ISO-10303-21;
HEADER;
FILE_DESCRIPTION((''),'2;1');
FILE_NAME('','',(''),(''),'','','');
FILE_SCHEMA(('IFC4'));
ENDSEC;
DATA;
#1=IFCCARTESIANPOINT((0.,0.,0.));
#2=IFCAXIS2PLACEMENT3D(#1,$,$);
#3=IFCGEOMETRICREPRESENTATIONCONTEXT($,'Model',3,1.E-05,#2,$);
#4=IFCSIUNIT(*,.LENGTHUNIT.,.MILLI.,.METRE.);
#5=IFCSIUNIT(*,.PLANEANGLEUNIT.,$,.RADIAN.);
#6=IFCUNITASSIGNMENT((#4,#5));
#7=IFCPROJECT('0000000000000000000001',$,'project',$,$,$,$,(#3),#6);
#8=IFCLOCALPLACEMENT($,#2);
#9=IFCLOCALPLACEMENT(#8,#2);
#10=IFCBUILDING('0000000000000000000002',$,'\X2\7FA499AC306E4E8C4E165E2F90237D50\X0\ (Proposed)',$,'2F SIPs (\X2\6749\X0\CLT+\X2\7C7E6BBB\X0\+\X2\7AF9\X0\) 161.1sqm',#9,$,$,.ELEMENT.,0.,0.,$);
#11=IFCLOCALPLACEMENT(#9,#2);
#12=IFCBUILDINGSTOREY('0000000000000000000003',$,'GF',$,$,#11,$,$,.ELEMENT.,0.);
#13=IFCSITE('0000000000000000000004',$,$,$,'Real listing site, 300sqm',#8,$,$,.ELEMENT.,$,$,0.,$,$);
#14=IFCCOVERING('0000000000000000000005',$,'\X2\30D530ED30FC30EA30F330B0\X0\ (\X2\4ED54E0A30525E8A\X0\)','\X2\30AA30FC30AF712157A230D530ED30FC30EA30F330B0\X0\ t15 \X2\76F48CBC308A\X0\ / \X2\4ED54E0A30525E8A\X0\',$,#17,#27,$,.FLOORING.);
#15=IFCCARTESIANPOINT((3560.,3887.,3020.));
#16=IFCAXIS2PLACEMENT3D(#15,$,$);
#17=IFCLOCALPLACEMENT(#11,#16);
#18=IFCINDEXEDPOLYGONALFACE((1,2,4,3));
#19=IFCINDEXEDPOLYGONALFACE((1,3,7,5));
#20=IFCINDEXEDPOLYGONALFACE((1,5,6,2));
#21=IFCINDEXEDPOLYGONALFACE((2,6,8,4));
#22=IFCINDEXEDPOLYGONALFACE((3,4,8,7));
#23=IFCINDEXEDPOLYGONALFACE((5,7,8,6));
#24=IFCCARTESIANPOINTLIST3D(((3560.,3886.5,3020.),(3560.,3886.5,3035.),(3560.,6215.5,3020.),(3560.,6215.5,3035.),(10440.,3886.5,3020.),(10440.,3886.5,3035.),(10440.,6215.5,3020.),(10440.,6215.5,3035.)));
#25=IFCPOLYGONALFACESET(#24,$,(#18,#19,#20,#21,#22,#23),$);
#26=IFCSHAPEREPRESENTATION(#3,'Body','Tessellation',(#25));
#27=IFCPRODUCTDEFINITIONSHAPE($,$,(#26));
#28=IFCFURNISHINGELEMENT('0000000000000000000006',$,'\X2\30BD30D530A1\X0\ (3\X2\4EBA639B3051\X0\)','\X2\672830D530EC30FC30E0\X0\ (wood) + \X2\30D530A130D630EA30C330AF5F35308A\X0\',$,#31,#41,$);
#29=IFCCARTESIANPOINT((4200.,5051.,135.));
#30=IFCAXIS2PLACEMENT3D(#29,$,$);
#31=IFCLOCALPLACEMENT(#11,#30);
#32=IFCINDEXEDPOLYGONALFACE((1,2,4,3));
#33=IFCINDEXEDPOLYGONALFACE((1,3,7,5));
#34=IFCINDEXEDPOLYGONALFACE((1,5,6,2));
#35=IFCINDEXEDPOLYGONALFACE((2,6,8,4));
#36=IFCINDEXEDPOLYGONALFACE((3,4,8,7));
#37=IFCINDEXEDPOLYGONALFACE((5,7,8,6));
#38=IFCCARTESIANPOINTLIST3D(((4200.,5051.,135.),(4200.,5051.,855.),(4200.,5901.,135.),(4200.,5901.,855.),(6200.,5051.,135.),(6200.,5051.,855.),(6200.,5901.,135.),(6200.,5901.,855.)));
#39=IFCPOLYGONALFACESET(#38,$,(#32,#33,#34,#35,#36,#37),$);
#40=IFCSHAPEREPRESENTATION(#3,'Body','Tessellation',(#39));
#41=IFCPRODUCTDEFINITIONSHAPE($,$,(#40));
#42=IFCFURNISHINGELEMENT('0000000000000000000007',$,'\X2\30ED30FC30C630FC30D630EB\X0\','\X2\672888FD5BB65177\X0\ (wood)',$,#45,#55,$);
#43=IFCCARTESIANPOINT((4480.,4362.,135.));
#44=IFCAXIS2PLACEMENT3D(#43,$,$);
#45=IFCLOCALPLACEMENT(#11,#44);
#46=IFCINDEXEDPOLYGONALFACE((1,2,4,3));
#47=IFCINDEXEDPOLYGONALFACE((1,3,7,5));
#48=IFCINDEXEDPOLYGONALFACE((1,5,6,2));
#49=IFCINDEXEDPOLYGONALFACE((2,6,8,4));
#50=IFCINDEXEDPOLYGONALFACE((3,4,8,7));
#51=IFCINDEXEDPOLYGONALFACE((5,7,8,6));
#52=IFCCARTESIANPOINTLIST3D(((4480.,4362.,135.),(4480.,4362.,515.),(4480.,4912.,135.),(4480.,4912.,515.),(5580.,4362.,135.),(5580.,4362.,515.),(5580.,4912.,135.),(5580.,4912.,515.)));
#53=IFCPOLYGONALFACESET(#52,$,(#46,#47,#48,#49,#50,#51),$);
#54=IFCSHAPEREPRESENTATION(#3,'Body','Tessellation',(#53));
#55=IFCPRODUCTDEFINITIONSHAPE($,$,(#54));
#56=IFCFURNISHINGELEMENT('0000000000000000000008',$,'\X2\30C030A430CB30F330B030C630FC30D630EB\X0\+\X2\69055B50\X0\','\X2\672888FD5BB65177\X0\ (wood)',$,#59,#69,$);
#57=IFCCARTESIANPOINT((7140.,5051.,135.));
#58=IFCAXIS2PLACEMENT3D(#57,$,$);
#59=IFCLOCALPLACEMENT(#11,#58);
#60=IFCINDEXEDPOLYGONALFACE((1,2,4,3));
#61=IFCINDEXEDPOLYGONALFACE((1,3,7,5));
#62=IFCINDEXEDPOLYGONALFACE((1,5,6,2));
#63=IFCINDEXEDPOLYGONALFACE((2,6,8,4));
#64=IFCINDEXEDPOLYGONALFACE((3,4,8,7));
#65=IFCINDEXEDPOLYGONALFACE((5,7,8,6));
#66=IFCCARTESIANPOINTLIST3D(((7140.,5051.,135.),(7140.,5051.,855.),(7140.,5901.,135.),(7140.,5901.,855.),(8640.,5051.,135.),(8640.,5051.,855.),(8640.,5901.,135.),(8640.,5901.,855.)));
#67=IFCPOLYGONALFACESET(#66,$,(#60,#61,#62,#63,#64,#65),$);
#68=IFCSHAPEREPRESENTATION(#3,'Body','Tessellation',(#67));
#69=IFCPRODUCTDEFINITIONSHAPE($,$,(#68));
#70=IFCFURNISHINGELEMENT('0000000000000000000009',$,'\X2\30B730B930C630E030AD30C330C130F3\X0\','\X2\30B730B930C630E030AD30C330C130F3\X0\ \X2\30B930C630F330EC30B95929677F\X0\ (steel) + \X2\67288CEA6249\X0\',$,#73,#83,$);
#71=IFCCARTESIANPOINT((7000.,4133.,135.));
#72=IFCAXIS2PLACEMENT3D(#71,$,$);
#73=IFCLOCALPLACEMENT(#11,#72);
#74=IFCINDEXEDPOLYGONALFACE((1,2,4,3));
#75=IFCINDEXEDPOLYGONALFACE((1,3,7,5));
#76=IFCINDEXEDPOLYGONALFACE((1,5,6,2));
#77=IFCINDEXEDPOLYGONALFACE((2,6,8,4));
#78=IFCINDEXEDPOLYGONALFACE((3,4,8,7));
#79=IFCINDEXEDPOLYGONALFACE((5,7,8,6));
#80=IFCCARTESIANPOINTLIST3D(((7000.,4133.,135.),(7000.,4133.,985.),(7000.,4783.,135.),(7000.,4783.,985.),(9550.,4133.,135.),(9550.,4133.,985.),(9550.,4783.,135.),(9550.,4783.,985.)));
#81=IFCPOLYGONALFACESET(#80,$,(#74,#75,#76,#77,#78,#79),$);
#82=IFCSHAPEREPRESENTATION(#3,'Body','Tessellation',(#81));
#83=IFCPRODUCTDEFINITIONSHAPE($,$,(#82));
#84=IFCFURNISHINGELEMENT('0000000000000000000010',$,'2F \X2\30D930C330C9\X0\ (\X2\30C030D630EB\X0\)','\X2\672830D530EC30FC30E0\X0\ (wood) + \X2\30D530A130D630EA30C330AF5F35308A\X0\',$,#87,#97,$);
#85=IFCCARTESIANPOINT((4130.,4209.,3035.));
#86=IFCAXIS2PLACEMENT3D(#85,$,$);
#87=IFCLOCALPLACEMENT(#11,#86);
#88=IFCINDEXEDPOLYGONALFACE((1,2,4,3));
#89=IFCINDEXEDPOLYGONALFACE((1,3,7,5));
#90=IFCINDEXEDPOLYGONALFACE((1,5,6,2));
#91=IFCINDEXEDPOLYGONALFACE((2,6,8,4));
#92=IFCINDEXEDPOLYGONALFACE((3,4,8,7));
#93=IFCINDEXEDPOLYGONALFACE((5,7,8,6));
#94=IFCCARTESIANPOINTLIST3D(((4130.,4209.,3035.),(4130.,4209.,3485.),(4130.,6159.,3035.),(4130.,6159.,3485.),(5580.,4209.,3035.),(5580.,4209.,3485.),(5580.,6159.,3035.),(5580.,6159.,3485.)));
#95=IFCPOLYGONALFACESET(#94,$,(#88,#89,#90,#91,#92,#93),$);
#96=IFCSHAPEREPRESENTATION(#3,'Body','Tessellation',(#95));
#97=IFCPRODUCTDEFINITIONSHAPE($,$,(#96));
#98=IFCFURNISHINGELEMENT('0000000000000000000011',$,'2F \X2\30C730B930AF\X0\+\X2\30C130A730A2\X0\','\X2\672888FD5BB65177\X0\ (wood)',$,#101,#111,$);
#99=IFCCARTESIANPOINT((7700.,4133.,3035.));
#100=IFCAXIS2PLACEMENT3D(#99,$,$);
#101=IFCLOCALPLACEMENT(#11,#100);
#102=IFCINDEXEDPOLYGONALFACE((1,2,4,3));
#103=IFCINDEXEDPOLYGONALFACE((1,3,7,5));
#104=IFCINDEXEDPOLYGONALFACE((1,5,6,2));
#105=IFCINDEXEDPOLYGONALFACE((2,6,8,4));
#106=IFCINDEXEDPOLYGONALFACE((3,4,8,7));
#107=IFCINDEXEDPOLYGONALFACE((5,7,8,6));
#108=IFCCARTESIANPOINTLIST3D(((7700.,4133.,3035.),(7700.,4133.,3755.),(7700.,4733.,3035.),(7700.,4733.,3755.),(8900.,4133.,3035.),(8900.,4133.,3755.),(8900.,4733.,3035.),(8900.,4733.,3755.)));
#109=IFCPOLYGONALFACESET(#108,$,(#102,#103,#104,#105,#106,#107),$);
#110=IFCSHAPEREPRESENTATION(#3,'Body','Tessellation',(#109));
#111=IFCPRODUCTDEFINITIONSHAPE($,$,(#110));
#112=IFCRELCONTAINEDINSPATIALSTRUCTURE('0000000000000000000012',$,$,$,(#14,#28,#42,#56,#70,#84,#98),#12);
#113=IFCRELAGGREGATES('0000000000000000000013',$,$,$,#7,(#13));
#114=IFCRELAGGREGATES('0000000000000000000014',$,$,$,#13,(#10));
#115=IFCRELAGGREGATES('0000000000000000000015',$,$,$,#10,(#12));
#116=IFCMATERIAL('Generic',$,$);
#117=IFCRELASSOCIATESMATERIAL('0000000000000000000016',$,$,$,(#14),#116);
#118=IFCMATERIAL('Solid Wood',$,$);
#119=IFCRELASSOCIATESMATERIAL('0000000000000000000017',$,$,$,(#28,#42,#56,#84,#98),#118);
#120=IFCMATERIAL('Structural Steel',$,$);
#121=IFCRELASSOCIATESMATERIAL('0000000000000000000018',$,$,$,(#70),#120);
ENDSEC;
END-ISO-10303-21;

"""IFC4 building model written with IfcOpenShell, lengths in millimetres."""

from ifc_helpers import new_model, si_unit, frame, frame_2d, origin, place, context, project, spatial, rectangle, extrude, material, element, save


model = new_model("IFC4")

# Units and contexts
model_context = context("Model", 3, precision=1e-05, world=origin())
ifc_project = project(units=[si_unit("LENGTHUNIT", "METRE", prefix="MILLI"), si_unit("PLANEANGLEUNIT", "RADIAN")], contexts=[model_context])

# Site, building, storey
site_placement = place(None, origin())
site = spatial("IfcSite", under=ifc_project, at=site_placement, ObjectType="Real listing site, 300sqm", CompositionType="ELEMENT", RefElevation=0.0)
building_placement = place(site_placement, origin())
building = spatial("IfcBuilding", under=site, at=building_placement, Name="群馬の二世帯連結 (Proposed)", ObjectType="2F SIPs (杉CLT+籾殻+竹) 161.1sqm", CompositionType="ELEMENT", ElevationOfRefHeight=0.0, ElevationOfTerrain=0.0)
storey_placement = place(building_placement, origin())
storey = spatial("IfcBuildingStorey", under=building, at=storey_placement, Name="GF", CompositionType="ELEMENT", Elevation=0.0)

# Shared definitions
ifc_material_1 = material(Name="Solid Wood")

# Shared definitions
ifc_material_2 = material(Name="Generic")

# Shared definitions
ifc_material_3 = material(Name="Structural Steel")

# Covering
covering_placement = place(storey_placement, frame((3560.0, 3887.0, 3020.0)))
element("IfcCovering", 1, at=covering_placement, inside=storey, material=ifc_material_2, Name="フローリング (仕上げ床)", Description="オーク無垢フローリング t15 直貼り / 仕上げ床", PredefinedType="FLOORING", context=model_context, shape_type="SweptSolid", body=[
    extrude(rectangle(XDim=6880.0, YDim=2329.0, at=frame_2d((3440.0, 1164.0))), frame((3560.0, 3887.0, 3020.0)), (0.0, 0.0, 1.0), 15.0),
])

# Furnishing elements
furnishing_1_placement = place(storey_placement, frame((4200.0, 5051.0, 135.0)))
element("IfcFurnishingElement", 2, at=furnishing_1_placement, inside=storey, material=ifc_material_1, Name="ソファ (3人掛け)", Description="木フレーム (wood) + ファブリック張り", context=model_context, shape_type="SweptSolid", body=[
    extrude(rectangle(XDim=2000.0, YDim=850.0, at=frame_2d((1000.0, 425.0))), frame((4200.0, 5051.0, 135.0)), (0.0, 0.0, 1.0), 720.0),
])
furnishing_2_placement = place(storey_placement, frame((4480.0, 4362.0, 135.0)))
element("IfcFurnishingElement", 3, at=furnishing_2_placement, inside=storey, material=ifc_material_1, Name="ローテーブル", Description="木製家具 (wood)", context=model_context, shape_type="SweptSolid", body=[
    extrude(rectangle(XDim=1100.0, YDim=550.0, at=frame_2d((550.0, 275.0))), frame((4480.0, 4362.0, 135.0)), (0.0, 0.0, 1.0), 380.0),
])
furnishing_3_placement = place(storey_placement, frame((7140.0, 5051.0, 135.0)))
element("IfcFurnishingElement", 4, at=furnishing_3_placement, inside=storey, material=ifc_material_1, Name="ダイニングテーブル+椅子", Description="木製家具 (wood)", context=model_context, shape_type="SweptSolid", body=[
    extrude(rectangle(XDim=1500.0, YDim=850.0, at=frame_2d((750.0, 425.0))), frame((7140.0, 5051.0, 135.0)), (0.0, 0.0, 1.0), 720.0),
])
furnishing_4_placement = place(storey_placement, frame((7000.0, 4133.0, 135.0)))
element("IfcFurnishingElement", 5, at=furnishing_4_placement, inside=storey, material=ifc_material_3, Name="システムキッチン", Description="システムキッチン ステンレス天板 (steel) + 木質扉", context=model_context, shape_type="SweptSolid", body=[
    extrude(rectangle(XDim=2550.0, YDim=650.0, at=frame_2d((1275.0, 325.0))), frame((7000.0, 4133.0, 135.0)), (0.0, 0.0, 1.0), 850.0),
])
furnishing_5_placement = place(storey_placement, frame((4130.0, 4209.0, 3035.0)))
element("IfcFurnishingElement", 6, at=furnishing_5_placement, inside=storey, material=ifc_material_1, Name="2F ベッド (ダブル)", Description="木フレーム (wood) + ファブリック張り", context=model_context, shape_type="SweptSolid", body=[
    extrude(rectangle(XDim=1450.0, YDim=1950.0, at=frame_2d((725.0, 975.0))), frame((4130.0, 4209.0, 3035.0)), (0.0, 0.0, 1.0), 450.0),
])
furnishing_6_placement = place(storey_placement, frame((7700.0, 4133.0, 3035.0)))
element("IfcFurnishingElement", 7, at=furnishing_6_placement, inside=storey, material=ifc_material_1, Name="2F デスク+チェア", Description="木製家具 (wood)", context=model_context, shape_type="SweptSolid", body=[
    extrude(rectangle(XDim=1200.0, YDim=600.0, at=frame_2d((600.0, 300.0))), frame((7700.0, 4133.0, 3035.0)), (0.0, 0.0, 1.0), 720.0),
])

save(model, "model.ifc")
